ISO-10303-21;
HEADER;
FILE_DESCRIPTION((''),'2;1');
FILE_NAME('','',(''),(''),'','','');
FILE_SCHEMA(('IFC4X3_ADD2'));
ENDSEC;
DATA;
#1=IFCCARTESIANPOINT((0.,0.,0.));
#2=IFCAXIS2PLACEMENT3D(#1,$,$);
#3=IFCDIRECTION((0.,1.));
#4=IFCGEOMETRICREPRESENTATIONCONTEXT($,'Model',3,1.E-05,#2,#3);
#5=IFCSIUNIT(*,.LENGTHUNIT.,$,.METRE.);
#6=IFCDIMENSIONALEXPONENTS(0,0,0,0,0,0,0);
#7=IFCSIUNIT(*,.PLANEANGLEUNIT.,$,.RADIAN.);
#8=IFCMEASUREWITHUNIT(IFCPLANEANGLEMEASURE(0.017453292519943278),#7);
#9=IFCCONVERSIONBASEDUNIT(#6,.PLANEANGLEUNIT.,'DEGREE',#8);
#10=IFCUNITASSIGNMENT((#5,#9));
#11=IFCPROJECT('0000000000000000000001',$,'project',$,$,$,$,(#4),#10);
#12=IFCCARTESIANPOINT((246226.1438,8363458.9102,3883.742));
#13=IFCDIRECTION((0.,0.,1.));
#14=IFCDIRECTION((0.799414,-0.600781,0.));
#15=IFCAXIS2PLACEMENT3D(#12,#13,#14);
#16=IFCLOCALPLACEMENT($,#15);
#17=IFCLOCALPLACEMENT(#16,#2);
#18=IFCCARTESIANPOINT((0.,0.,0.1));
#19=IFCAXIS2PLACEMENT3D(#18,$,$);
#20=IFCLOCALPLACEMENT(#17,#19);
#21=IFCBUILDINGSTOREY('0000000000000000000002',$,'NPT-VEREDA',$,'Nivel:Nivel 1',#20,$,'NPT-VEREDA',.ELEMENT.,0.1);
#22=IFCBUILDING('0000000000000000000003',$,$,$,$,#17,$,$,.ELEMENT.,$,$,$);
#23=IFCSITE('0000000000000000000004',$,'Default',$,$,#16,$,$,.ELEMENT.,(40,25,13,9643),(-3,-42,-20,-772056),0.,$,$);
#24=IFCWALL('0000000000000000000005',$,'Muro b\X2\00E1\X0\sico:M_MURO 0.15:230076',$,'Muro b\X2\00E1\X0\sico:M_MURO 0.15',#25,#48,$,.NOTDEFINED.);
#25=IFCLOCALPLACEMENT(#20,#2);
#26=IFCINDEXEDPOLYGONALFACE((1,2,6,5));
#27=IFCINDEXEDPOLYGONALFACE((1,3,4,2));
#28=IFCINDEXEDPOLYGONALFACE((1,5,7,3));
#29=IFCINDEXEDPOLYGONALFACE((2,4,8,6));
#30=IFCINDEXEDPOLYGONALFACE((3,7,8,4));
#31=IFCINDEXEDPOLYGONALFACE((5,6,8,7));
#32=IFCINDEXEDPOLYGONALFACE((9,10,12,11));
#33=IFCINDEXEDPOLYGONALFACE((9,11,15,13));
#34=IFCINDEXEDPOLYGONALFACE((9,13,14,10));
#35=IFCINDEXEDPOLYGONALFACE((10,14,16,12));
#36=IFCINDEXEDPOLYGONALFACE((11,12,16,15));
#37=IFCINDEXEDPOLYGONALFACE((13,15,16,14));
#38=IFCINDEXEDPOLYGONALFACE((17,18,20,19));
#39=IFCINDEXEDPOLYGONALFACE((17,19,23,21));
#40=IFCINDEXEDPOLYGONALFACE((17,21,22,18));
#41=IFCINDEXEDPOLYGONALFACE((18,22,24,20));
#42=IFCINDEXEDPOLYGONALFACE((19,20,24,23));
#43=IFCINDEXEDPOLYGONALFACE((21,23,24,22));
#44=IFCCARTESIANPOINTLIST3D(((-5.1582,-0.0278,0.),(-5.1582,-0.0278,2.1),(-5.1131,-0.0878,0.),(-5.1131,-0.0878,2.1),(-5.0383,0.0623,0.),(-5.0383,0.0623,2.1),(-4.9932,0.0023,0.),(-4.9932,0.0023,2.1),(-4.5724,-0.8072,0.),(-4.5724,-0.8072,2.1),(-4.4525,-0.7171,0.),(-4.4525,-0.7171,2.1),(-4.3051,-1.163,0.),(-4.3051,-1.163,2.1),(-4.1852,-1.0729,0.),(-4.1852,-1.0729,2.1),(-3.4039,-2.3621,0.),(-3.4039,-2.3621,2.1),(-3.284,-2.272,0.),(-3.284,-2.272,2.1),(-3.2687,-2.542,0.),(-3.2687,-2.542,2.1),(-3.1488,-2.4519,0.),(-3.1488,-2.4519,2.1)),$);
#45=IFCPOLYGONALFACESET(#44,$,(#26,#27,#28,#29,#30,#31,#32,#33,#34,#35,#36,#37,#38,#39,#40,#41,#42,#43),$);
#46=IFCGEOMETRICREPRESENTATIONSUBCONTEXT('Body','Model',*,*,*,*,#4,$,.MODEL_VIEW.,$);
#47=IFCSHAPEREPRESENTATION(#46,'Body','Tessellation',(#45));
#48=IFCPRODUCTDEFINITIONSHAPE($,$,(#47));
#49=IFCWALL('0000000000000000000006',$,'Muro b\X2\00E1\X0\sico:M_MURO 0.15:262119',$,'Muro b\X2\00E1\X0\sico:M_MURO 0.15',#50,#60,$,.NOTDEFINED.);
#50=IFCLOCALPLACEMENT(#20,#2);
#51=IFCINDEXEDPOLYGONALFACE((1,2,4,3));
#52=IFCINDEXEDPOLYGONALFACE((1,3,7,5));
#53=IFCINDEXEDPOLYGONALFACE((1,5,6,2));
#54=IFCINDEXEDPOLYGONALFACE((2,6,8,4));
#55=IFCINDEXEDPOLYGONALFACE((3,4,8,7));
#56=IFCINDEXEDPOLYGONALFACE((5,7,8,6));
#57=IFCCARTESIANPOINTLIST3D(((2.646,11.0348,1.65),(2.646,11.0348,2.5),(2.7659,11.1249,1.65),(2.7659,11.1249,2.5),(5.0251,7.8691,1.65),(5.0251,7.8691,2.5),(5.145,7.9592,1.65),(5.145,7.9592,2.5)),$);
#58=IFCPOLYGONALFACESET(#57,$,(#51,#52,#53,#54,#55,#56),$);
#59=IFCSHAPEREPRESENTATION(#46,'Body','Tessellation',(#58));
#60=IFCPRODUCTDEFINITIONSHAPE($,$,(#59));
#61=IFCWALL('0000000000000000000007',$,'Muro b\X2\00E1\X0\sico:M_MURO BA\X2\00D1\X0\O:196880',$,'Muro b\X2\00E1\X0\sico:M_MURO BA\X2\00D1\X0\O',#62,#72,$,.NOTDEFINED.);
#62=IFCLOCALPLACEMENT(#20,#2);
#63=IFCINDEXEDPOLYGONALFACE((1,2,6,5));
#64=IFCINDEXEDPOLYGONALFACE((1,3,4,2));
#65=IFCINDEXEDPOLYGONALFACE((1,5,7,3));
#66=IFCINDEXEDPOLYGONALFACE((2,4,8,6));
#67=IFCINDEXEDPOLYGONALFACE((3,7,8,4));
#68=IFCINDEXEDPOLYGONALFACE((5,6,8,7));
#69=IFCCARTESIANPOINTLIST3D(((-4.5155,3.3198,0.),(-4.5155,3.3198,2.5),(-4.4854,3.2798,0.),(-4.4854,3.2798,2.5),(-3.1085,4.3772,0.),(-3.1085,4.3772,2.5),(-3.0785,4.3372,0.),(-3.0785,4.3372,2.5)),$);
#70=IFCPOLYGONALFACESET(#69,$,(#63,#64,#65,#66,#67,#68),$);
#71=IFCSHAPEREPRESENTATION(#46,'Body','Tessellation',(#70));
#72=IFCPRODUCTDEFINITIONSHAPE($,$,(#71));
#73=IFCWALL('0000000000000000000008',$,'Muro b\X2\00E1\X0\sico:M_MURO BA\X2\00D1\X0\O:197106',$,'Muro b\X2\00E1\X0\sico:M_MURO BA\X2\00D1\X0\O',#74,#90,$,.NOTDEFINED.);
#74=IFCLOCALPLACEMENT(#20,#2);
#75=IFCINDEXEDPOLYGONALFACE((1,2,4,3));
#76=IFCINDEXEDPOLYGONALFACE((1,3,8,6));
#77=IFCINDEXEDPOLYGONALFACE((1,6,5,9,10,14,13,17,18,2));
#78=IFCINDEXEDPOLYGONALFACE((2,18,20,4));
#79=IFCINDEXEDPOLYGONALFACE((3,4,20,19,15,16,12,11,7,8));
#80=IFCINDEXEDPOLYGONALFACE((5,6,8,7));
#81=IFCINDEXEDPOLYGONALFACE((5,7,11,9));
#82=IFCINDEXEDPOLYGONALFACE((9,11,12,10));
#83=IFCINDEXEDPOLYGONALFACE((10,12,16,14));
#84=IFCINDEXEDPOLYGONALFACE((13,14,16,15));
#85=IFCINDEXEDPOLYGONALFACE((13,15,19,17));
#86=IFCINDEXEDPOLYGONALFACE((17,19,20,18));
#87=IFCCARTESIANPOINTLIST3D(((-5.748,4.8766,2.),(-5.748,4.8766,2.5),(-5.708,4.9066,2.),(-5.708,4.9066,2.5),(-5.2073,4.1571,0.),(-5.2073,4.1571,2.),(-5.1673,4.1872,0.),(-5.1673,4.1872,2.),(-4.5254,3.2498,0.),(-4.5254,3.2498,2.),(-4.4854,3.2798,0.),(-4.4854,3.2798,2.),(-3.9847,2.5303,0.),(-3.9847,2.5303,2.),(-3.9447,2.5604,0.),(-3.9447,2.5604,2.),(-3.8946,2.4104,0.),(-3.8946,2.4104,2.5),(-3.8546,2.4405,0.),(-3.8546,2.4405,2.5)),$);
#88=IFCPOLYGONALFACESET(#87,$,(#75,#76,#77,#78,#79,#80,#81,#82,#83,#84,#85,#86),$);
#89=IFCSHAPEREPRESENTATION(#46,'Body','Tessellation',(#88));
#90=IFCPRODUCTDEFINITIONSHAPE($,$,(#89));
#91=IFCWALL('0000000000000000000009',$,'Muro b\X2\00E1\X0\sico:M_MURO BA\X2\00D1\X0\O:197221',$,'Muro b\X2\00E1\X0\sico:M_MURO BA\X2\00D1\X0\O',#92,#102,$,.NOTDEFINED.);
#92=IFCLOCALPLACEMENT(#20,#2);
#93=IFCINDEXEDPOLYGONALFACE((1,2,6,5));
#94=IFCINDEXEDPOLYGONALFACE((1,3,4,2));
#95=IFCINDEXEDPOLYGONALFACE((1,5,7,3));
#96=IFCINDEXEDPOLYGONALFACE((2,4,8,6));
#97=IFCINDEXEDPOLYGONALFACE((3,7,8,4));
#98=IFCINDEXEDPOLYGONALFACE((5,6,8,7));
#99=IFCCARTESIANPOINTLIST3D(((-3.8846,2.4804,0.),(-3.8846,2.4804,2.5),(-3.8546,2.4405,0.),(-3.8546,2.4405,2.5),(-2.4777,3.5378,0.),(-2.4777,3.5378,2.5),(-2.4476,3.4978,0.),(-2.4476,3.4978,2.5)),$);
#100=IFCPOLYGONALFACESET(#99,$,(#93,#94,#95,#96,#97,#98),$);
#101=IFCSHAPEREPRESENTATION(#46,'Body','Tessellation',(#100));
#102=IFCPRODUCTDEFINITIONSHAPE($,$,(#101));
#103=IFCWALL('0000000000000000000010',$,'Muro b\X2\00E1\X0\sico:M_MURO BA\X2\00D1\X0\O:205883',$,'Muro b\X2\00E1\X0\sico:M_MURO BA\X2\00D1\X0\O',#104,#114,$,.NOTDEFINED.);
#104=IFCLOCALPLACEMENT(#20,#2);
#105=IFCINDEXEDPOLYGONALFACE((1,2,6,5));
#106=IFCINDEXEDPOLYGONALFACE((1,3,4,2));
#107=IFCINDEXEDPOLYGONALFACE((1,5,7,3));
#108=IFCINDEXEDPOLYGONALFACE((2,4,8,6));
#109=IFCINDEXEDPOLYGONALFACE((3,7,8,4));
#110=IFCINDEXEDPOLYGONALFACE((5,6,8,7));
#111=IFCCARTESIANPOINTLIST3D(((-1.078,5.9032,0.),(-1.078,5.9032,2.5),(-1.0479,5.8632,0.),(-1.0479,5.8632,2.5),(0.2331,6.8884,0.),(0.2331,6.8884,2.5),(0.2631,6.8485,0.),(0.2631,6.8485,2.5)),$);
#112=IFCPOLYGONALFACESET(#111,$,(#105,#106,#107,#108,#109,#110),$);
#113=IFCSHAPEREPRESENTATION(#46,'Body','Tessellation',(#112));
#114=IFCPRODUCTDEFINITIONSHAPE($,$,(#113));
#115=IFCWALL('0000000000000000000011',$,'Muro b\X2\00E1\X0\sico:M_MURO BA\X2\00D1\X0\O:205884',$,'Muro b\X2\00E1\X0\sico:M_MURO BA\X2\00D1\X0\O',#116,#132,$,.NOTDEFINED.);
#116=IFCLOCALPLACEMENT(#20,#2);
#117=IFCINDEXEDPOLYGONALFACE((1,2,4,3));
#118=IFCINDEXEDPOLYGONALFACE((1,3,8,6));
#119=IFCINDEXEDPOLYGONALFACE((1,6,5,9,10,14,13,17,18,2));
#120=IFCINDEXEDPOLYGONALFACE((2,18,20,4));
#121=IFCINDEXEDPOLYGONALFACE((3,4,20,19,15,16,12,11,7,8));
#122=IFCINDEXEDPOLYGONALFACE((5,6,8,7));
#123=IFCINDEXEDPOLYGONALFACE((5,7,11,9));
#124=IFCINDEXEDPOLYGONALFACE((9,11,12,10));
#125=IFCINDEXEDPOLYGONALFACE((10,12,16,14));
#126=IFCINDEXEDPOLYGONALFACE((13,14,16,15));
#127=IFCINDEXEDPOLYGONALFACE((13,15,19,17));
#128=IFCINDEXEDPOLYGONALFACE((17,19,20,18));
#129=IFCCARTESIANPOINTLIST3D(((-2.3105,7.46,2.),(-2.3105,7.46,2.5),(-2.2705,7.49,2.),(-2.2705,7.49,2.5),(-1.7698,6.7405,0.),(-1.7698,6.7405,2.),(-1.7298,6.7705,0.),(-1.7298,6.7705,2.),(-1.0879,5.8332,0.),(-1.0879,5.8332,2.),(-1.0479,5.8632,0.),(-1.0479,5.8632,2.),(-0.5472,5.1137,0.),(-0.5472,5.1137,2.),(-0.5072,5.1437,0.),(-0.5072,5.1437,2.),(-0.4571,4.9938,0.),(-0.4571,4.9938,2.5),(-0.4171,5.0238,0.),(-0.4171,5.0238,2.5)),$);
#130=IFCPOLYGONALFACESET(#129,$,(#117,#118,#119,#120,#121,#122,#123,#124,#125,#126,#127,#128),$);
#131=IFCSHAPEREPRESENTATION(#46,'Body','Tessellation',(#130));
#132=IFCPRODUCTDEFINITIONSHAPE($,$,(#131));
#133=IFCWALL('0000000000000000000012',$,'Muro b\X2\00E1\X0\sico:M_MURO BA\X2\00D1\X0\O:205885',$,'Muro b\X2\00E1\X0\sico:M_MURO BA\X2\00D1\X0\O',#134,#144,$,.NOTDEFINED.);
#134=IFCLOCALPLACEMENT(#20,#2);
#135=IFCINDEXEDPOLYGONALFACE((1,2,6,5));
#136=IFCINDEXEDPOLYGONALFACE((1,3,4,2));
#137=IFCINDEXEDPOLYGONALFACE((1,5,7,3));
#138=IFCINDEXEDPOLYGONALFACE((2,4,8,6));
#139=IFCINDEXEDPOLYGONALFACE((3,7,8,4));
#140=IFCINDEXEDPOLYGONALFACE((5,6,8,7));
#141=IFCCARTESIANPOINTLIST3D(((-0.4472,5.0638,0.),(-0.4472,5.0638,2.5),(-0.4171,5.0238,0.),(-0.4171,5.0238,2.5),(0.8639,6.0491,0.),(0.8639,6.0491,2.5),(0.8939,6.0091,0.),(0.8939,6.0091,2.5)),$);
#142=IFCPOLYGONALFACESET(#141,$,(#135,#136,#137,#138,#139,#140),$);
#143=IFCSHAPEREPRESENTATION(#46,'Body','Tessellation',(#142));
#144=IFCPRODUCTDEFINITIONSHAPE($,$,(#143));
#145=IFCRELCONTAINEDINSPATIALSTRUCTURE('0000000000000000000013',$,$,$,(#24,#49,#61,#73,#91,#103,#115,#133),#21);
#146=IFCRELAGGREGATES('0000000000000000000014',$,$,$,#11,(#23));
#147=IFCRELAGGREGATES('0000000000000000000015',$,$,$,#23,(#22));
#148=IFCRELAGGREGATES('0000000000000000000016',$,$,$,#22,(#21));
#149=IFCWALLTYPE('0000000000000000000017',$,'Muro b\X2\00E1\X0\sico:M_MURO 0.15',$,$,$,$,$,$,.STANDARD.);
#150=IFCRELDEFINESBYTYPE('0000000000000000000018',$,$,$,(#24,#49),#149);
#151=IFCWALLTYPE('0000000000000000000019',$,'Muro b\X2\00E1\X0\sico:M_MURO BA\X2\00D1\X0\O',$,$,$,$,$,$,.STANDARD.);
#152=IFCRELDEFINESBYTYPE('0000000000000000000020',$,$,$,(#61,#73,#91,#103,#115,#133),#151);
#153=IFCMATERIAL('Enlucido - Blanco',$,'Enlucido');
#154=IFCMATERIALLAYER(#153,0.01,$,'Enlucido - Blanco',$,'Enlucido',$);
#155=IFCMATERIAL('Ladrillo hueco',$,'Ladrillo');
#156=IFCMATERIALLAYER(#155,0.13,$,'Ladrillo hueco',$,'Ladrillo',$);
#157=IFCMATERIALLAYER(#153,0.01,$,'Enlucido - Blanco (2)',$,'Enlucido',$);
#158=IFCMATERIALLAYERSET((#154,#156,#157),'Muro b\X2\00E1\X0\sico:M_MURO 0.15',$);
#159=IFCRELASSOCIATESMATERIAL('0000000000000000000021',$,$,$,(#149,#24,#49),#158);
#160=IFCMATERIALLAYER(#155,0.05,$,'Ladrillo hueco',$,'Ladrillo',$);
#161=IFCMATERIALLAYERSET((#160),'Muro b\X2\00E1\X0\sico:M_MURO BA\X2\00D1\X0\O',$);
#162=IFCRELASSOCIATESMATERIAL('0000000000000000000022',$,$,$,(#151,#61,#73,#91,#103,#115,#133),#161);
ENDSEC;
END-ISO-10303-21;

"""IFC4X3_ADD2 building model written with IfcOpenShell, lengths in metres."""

from ifc_helpers import new_model, entity, si_unit, converted_unit, direction, frame, frame_2d, origin, place, context, subcontext, project, spatial, rectangle, extrude, material, layer, layer_set, type_object, element, save


model = new_model("IFC4X3_ADD2")

# Units and contexts
model_context = context("Model", 3, precision=1e-05, world=origin(), true_north=direction((0.0, 1.0)))
body_context = subcontext(model_context, "Body", "Model", "MODEL_VIEW")
ifc_project = project(units=[si_unit("LENGTHUNIT", "METRE"), converted_unit("PLANEANGLEUNIT", "DEGREE", entity("IfcPlaneAngleMeasure", 0.017453292519943278), si_unit("PLANEANGLEUNIT", "RADIAN"), dimensions=[0, 0, 0, 0, 0, 0, 0])], contexts=[model_context])

# Site, building, storey
site_placement = place(None, frame((246226.1438, 8363458.9102, 3883.742), z_axis=(0.0, 0.0, 1.0), x_axis=(0.799414, -0.600781, 0.0)))
site = spatial("IfcSite", under=ifc_project, at=site_placement, Name="Default", CompositionType="ELEMENT", RefLatitude=(40, 25, 13, 9643), RefLongitude=(-3, -42, -20, -772056), RefElevation=0.0)
building_placement = place(site_placement, origin())
building = spatial("IfcBuilding", under=site, at=building_placement, CompositionType="ELEMENT")
storey_placement = place(building_placement, frame((0.0, 0.0, 0.1)))
storey = spatial("IfcBuildingStorey", under=building, at=storey_placement, Name="NPT-VEREDA", ObjectType="Nivel:Nivel 1", LongName="NPT-VEREDA", CompositionType="ELEMENT", Elevation=0.1)

# Shared definitions
ifc_material_1 = material(Name="Enlucido - Blanco", Category="Enlucido")
ifc_layer_1 = layer(ifc_material_1, 0.01, Name="Enlucido - Blanco", Category="Enlucido")
ifc_material_2 = material(Name="Ladrillo hueco", Category="Ladrillo")
ifc_layer_2 = layer(ifc_material_2, 0.13, Name="Ladrillo hueco", Category="Ladrillo")
ifc_layer_3 = layer(ifc_material_1, 0.01, Name="Enlucido - Blanco (2)", Category="Enlucido")
ifc_layer_set_1 = layer_set([ifc_layer_1, ifc_layer_2, ifc_layer_3], Name="Muro básico:M_MURO 0.15")
wall_type_1 = type_object("IfcWallType", Name="Muro básico:M_MURO 0.15", PredefinedType="STANDARD", material=ifc_layer_set_1)

# Wall, openings
wall_1_placement = place(storey_placement, frame((-3.2088, -2.4969, 0.0), z_axis=(0.0, 0.0, 1.0), x_axis=(-0.60078, 0.799414, 0.0)))
wall_1 = element("IfcWall", 1, at=wall_1_placement, inside=storey, type_object=wall_type_1, material=ifc_layer_set_1, Name="Muro básico:M_MURO 0.15:230076", ObjectType="Muro básico:M_MURO 0.15", PredefinedType="NOTDEFINED", context=body_context, shape_type="SweptSolid", body=[
    extrude(rectangle(XDim=3.145, YDim=0.15, at=frame_2d((1.5725, 0.0), x_axis=(-1.0, 0.0))), origin(), (0.0, 0.0, 1.0), 2.1),
])
opening_1_placement = place(wall_1_placement, frame((0.225, -0.075, 0.0)))
element("IfcOpeningElement", 2, at=opening_1_placement, cuts=wall_1, PredefinedType="OPENING", context=body_context, shape_type="SweptSolid", body=[
    extrude(rectangle(XDim=2.1, YDim=1.5, at=frame_2d((1.05, 0.75), x_axis=(1.0, 0.0))), frame((0.0, 0.0, 0.0), z_axis=(0.0, 1.0, 0.0), x_axis=(0.0, 0.0, 1.0)), (0.0, 0.0, 1.0), 0.15),
])
opening_2_placement = place(wall_1_placement, frame((3.07, 0.075, 0.0)))
element("IfcOpeningElement", 3, at=opening_2_placement, cuts=wall_1, PredefinedType="OPENING", context=body_context, shape_type="SweptSolid", body=[
    extrude(rectangle(XDim=2.1, YDim=0.9, at=frame_2d((1.05, 0.45), x_axis=(1.0, 0.0))), frame((0.0, 0.0, 0.0), z_axis=(0.0, -1.0, 0.0), x_axis=(0.0, 0.0, 1.0)), (0.0, 0.0, 1.0), 0.15),
])

# Walls
wall_2_placement = place(storey_placement, frame((2.706, 11.0799, 1.65), z_axis=(0.0, 0.0, 1.0), x_axis=(0.60078, -0.799414, 0.0)))
element("IfcWall", 4, at=wall_2_placement, inside=storey, type_object=wall_type_1, material=ifc_layer_set_1, Name="Muro básico:M_MURO 0.15:262119", ObjectType="Muro básico:M_MURO 0.15", PredefinedType="NOTDEFINED", context=body_context, shape_type="SweptSolid", body=[
    extrude(rectangle(XDim=3.96, YDim=0.15, at=frame_2d((1.98, 0.0), x_axis=(-1.0, 0.0))), origin(), (0.0, 0.0, 1.0), 0.85),
])
ifc_layer_4 = layer(ifc_material_2, 0.05, Name="Ladrillo hueco", Category="Ladrillo")
ifc_layer_set_2 = layer_set([ifc_layer_4], Name="Muro básico:M_MURO BAÑO")
wall_type_2 = type_object("IfcWallType", Name="Muro básico:M_MURO BAÑO", PredefinedType="STANDARD", material=ifc_layer_set_2)
wall_3_placement = place(storey_placement, frame((-3.0935, 4.3572, 0.0), z_axis=(0.0, 0.0, 1.0), x_axis=(-0.799414, -0.60078, 0.0)))
element("IfcWall", 5, at=wall_3_placement, inside=storey, type_object=wall_type_2, material=ifc_layer_set_2, Name="Muro básico:M_MURO BAÑO:196880", ObjectType="Muro básico:M_MURO BAÑO", PredefinedType="NOTDEFINED", context=body_context, shape_type="SweptSolid", body=[
    extrude(rectangle(XDim=1.76, YDim=0.05, at=frame_2d((0.88, 0.0), x_axis=(-1.0, 0.0))), origin(), (0.0, 0.0, 1.0), 2.5),
])

# Wall, openings
wall_4_placement = place(storey_placement, frame((-5.728, 4.8916, 0.0), z_axis=(0.0, 0.0, 1.0), x_axis=(0.60078, -0.799414, 0.0)))
wall_4 = element("IfcWall", 6, at=wall_4_placement, inside=storey, type_object=wall_type_2, material=ifc_layer_set_2, Name="Muro básico:M_MURO BAÑO:197106", ObjectType="Muro básico:M_MURO BAÑO", PredefinedType="NOTDEFINED", context=body_context, shape_type="SweptSolid", body=[
    extrude(rectangle(XDim=3.085, YDim=0.05, at=frame_2d((1.5425, 0.0), x_axis=(-1.0, 0.0))), origin(), (0.0, 0.0, 1.0), 2.5),
])
opening_3_placement = place(wall_4_placement, frame((0.9, 0.025, -0.1)))
element("IfcOpeningElement", 7, at=opening_3_placement, cuts=wall_4, PredefinedType="OPENING", context=body_context, shape_type="SweptSolid", body=[
    extrude(rectangle(XDim=2.1, YDim=0.9, at=frame_2d((1.05, 0.45), x_axis=(1.0, 0.0))), frame((0.0, 0.0, 0.0), z_axis=(0.0, -1.0, 0.0), x_axis=(0.0, 0.0, 1.0)), (0.0, 0.0, 1.0), 0.05),
])
opening_4_placement = place(wall_4_placement, frame((2.935, 0.025, -0.1)))
element("IfcOpeningElement", 8, at=opening_4_placement, cuts=wall_4, PredefinedType="OPENING", context=body_context, shape_type="SweptSolid", body=[
    extrude(rectangle(XDim=2.1, YDim=0.9, at=frame_2d((1.05, 0.45), x_axis=(1.0, 0.0))), frame((0.0, 0.0, 0.0), z_axis=(0.0, -1.0, 0.0), x_axis=(0.0, 0.0, 1.0)), (0.0, 0.0, 1.0), 0.05),
])

# Walls
wall_5_placement = place(storey_placement, frame((-2.4627, 3.5178, 0.0), z_axis=(0.0, 0.0, 1.0), x_axis=(-0.799414, -0.60078, 0.0)))
element("IfcWall", 9, at=wall_5_placement, inside=storey, type_object=wall_type_2, material=ifc_layer_set_2, Name="Muro básico:M_MURO BAÑO:197221", ObjectType="Muro básico:M_MURO BAÑO", PredefinedType="NOTDEFINED", context=body_context, shape_type="SweptSolid", body=[
    extrude(rectangle(XDim=1.76, YDim=0.05, at=frame_2d((0.88, 0.0), x_axis=(-1.0, 0.0))), origin(), (0.0, 0.0, 1.0), 2.5),
])
wall_6_placement = place(storey_placement, frame((0.2481, 6.8685, 0.0), z_axis=(0.0, 0.0, 1.0), x_axis=(-0.799414, -0.60078, 0.0)))
element("IfcWall", 10, at=wall_6_placement, inside=storey, type_object=wall_type_2, material=ifc_layer_set_2, Name="Muro básico:M_MURO BAÑO:205883", ObjectType="Muro básico:M_MURO BAÑO", PredefinedType="NOTDEFINED", context=body_context, shape_type="SweptSolid", body=[
    extrude(rectangle(XDim=1.64, YDim=0.05, at=frame_2d((0.82, 0.0), x_axis=(-1.0, 0.0))), origin(), (0.0, 0.0, 1.0), 2.5),
])

# Wall, openings
wall_7_placement = place(storey_placement, frame((-2.2905, 7.475, 0.0), z_axis=(0.0, 0.0, 1.0), x_axis=(0.60078, -0.799414, 0.0)))
wall_7 = element("IfcWall", 11, at=wall_7_placement, inside=storey, type_object=wall_type_2, material=ifc_layer_set_2, Name="Muro básico:M_MURO BAÑO:205884", ObjectType="Muro básico:M_MURO BAÑO", PredefinedType="NOTDEFINED", context=body_context, shape_type="SweptSolid", body=[
    extrude(rectangle(XDim=3.085, YDim=0.05, at=frame_2d((1.5425, 0.0), x_axis=(1.0, 0.0))), origin(), (0.0, 0.0, 1.0), 2.5),
])
opening_5_placement = place(wall_7_placement, frame((0.9, 0.025, -0.1)))
element("IfcOpeningElement", 12, at=opening_5_placement, cuts=wall_7, PredefinedType="OPENING", context=body_context, shape_type="SweptSolid", body=[
    extrude(rectangle(XDim=2.1, YDim=0.9, at=frame_2d((1.05, 0.45), x_axis=(1.0, 0.0))), frame((0.0, 0.0, 0.0), z_axis=(0.0, -1.0, 0.0), x_axis=(0.0, 0.0, 1.0)), (0.0, 0.0, 1.0), 0.05),
])
opening_6_placement = place(wall_7_placement, frame((2.935, 0.025, -0.1)))
element("IfcOpeningElement", 13, at=opening_6_placement, cuts=wall_7, PredefinedType="OPENING", context=body_context, shape_type="SweptSolid", body=[
    extrude(rectangle(XDim=2.1, YDim=0.9, at=frame_2d((1.05, 0.45), x_axis=(1.0, 0.0))), frame((0.0, 0.0, 0.0), z_axis=(0.0, -1.0, 0.0), x_axis=(0.0, 0.0, 1.0)), (0.0, 0.0, 1.0), 0.05),
])

# Wall
wall_8_placement = place(storey_placement, frame((0.8789, 6.0291, 0.0), z_axis=(0.0, 0.0, 1.0), x_axis=(-0.799414, -0.60078, 0.0)))
element("IfcWall", 14, at=wall_8_placement, inside=storey, type_object=wall_type_2, material=ifc_layer_set_2, Name="Muro básico:M_MURO BAÑO:205885", ObjectType="Muro básico:M_MURO BAÑO", PredefinedType="NOTDEFINED", context=body_context, shape_type="SweptSolid", body=[
    extrude(rectangle(XDim=1.64, YDim=0.05, at=frame_2d((0.82, 0.0), x_axis=(-1.0, 0.0))), origin(), (0.0, 0.0, 1.0), 2.5),
])

save(model, "model.ifc")
